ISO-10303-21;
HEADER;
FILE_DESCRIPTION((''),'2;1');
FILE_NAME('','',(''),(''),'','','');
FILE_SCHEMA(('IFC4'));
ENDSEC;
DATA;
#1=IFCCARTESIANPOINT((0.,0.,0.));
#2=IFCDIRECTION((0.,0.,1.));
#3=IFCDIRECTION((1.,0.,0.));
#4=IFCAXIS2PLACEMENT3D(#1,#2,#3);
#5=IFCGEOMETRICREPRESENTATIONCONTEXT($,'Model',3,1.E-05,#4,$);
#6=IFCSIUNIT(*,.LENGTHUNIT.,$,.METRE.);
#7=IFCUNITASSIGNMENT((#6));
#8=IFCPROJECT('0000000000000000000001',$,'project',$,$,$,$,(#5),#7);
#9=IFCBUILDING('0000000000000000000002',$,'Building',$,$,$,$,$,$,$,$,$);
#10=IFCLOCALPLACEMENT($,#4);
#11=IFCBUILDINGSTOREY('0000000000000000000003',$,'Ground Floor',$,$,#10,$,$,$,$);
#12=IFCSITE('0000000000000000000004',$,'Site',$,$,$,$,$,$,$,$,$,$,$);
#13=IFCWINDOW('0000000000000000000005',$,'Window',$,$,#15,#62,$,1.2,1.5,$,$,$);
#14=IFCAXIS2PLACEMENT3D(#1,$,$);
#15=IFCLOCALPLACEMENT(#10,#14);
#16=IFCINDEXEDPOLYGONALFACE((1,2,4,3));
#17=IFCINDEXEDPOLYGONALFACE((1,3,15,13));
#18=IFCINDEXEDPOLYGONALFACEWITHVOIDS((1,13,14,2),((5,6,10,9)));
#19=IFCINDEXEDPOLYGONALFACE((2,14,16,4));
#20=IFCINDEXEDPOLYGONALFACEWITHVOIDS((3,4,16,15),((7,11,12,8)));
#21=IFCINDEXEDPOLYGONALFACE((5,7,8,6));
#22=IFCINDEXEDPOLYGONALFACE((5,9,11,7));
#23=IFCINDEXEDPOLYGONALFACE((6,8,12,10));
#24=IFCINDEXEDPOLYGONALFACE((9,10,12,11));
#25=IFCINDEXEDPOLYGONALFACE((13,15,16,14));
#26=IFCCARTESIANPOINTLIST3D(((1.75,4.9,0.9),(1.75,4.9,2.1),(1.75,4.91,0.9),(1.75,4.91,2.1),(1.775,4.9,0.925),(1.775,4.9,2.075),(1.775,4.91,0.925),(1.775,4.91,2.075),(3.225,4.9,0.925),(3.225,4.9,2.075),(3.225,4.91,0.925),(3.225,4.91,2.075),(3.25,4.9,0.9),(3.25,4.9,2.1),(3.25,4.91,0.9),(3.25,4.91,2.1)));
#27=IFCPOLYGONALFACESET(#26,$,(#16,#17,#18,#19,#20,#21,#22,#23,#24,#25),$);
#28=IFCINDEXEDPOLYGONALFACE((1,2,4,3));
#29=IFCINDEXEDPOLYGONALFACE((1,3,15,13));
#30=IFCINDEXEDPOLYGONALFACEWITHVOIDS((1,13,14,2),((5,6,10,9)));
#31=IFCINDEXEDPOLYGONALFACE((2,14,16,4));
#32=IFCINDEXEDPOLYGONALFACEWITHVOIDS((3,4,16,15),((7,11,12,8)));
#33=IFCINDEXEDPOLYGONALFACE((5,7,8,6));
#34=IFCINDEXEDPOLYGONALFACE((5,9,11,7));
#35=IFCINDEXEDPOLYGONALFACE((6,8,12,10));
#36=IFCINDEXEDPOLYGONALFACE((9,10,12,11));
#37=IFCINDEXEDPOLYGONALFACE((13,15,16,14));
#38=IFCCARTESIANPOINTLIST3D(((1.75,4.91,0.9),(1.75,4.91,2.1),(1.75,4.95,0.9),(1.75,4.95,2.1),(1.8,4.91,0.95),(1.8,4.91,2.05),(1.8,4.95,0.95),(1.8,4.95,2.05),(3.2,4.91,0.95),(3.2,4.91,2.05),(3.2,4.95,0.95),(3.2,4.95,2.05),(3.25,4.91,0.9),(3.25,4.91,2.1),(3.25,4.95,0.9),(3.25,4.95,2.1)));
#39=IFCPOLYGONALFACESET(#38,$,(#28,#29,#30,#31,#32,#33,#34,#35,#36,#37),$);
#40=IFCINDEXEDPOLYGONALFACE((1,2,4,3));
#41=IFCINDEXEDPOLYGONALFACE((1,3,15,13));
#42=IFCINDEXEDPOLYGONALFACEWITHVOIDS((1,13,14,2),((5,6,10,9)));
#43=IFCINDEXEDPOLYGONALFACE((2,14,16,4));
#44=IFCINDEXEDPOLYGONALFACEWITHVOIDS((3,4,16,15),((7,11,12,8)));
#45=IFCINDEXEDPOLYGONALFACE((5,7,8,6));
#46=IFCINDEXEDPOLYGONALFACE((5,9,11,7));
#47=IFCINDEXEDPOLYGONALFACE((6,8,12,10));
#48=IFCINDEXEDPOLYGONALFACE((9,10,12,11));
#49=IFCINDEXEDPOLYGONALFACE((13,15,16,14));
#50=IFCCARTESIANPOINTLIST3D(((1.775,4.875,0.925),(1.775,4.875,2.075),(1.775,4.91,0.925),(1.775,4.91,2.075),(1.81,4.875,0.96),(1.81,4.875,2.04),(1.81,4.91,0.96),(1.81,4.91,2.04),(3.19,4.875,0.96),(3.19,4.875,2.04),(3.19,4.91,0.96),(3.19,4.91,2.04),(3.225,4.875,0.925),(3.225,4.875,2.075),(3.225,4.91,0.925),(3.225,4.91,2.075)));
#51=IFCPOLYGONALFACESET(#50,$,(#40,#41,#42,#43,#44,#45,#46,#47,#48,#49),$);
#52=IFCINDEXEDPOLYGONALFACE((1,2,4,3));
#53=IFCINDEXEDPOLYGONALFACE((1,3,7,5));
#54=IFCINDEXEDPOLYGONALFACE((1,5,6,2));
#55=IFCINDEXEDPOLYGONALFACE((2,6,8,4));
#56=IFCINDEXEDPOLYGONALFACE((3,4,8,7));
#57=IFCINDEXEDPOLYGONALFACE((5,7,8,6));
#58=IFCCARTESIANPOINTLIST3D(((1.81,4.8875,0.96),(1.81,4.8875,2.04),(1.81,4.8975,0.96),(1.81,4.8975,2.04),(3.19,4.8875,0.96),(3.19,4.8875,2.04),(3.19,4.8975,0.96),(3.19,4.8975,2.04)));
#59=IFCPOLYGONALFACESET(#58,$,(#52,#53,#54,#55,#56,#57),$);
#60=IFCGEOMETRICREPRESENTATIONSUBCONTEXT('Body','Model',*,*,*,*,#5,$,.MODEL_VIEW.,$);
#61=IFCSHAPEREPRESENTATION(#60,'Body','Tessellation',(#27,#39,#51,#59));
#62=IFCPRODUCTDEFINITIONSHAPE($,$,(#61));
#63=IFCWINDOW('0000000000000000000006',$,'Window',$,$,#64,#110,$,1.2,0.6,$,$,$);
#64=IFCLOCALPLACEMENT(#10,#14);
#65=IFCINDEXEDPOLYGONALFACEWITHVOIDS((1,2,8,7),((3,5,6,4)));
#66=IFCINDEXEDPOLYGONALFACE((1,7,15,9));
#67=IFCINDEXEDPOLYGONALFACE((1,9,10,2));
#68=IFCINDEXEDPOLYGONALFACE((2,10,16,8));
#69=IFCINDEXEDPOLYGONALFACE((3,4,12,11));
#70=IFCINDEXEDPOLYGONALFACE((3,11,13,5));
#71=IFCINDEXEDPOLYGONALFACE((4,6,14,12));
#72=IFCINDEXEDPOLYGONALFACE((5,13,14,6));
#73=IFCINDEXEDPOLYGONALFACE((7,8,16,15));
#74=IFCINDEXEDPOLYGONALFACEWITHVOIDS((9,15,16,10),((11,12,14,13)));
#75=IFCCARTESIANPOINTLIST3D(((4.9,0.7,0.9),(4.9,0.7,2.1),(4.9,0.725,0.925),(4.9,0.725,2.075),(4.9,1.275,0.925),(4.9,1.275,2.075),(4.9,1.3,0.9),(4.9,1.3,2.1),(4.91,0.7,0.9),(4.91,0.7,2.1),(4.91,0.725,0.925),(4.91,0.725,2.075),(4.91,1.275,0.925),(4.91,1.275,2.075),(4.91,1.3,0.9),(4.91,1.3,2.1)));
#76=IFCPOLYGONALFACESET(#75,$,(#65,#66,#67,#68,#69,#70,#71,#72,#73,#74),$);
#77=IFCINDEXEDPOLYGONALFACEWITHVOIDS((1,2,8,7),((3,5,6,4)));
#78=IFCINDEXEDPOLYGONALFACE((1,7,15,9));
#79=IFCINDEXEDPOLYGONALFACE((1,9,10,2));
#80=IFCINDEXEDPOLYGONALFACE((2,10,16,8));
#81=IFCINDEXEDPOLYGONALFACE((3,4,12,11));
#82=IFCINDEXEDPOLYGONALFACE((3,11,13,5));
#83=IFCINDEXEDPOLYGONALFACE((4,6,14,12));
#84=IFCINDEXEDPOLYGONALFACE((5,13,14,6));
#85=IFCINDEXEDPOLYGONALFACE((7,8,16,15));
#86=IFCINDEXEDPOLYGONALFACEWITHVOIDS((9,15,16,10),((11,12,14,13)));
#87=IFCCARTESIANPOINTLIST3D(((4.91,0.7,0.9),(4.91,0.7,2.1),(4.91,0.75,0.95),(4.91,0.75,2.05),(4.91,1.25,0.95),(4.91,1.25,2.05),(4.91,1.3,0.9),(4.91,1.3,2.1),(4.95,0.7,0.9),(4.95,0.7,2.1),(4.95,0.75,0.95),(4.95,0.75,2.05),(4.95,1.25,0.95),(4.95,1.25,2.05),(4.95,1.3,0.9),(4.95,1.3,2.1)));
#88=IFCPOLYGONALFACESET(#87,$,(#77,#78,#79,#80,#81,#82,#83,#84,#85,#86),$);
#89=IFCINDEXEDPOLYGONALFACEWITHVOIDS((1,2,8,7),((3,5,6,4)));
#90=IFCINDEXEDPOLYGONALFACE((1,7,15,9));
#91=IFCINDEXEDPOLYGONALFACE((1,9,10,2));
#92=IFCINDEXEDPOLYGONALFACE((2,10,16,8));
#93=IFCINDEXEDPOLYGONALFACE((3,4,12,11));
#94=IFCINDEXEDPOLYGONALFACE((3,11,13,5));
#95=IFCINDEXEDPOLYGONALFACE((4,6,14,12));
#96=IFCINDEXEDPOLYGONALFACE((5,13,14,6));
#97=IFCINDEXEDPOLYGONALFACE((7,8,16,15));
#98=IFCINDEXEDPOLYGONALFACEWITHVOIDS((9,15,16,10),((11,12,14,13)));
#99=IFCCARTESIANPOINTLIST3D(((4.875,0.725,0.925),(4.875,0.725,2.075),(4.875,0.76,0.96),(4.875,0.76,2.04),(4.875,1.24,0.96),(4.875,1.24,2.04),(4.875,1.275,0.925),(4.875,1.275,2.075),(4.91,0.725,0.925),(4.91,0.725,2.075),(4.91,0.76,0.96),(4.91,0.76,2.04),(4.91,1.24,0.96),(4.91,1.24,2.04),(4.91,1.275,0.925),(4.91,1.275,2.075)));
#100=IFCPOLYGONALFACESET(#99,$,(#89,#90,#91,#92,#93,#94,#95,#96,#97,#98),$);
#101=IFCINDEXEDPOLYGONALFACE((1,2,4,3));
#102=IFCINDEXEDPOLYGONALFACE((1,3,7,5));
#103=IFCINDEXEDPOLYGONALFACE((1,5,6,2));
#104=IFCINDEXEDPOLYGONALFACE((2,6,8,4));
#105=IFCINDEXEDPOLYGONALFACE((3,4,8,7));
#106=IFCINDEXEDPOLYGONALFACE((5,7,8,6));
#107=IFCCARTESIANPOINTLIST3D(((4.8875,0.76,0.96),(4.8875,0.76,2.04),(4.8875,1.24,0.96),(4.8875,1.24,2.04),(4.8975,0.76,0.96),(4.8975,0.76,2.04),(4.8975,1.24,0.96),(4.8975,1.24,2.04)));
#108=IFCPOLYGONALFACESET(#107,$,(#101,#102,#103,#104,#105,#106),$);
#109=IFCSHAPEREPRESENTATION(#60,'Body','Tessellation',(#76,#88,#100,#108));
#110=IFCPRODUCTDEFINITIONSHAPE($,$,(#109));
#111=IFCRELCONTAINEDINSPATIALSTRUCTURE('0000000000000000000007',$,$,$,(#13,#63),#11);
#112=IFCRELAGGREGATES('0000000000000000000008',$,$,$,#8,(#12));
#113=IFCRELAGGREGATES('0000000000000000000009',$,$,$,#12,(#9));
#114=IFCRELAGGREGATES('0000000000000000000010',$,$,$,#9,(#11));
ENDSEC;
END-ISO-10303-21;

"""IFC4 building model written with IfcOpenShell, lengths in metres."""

from ifc_helpers import new_model, si_unit, frame, origin_with_axes, place, context, subcontext, project, spatial, line, indexed_curve, outline, extrude, element, save


model = new_model("IFC4")

# Units and contexts
model_context = context("Model", 3, precision=1e-05, world=origin_with_axes())
body_context = subcontext(model_context, "Body", "Model", "MODEL_VIEW")
ifc_project = project(units=[si_unit("LENGTHUNIT", "METRE")], contexts=[model_context])

# Site, building, storey
site = spatial("IfcSite", under=ifc_project, Name="Site")
building = spatial("IfcBuilding", under=site, Name="Building")
storey_placement = place(None, origin_with_axes())
storey = spatial("IfcBuildingStorey", under=building, at=storey_placement, Name="Ground Floor")

# Windows
window_1_placement = place(storey_placement, frame((3.25, 5.0, 0.9), z_axis=(0.0, 0.0, 1.0), x_axis=(-1.0, 0.0, 0.0)))
element("IfcWindow", 1, at=window_1_placement, inside=storey, Name="Window", OverallHeight=1.2, OverallWidth=1.5, context=body_context, shape_type="SweptSolid", body=[
    extrude(outline(indexed_curve([(0.0, 0.0), (1.5, 0.0), (1.5, 1.2), (0.0, 1.2)], segments=[line(1, 2, 3, 4, 1)]), holes=[indexed_curve([(0.025, 0.025), (1.475, 0.025), (1.475, 1.175), (0.025, 1.175)], segments=[line(1, 2, 3, 4, 1)])]), frame((0.0, 0.09, 0.0), z_axis=(0.0, -1.0, 0.0), x_axis=(1.0, 0.0, 0.0)), (0.0, 0.0, -1.0), 0.01),
    extrude(outline(indexed_curve([(0.0, 0.0), (1.5, 0.0), (1.5, 1.2), (0.0, 1.2)], segments=[line(1, 2, 3, 4, 1)]), holes=[indexed_curve([(0.05, 0.05), (1.45, 0.05), (1.45, 1.15), (0.05, 1.15)], segments=[line(1, 2, 3, 4, 1)])]), frame((0.0, 0.05, 0.0), z_axis=(0.0, -1.0, 0.0), x_axis=(1.0, 0.0, 0.0)), (0.0, 0.0, -1.0), 0.04),
    extrude(outline(indexed_curve([(0.0, 0.0), (1.45, 0.0), (1.45, 1.15), (0.0, 1.15)], segments=[line(1, 2, 3, 4, 1)]), holes=[indexed_curve([(0.035, 0.035), (1.415, 0.035), (1.415, 1.115), (0.035, 1.115)], segments=[line(1, 2, 3, 4, 1)])]), frame((0.025, 0.09, 0.025), z_axis=(0.0, -1.0, 0.0), x_axis=(1.0, 0.0, 0.0)), (0.0, 0.0, -1.0), 0.035),
    extrude(outline(indexed_curve([(0.035, 0.035), (1.415, 0.035), (1.415, 1.115), (0.035, 1.115)], segments=[line(1, 2, 3, 4, 1)])), frame((0.025, 0.1025, 0.025), z_axis=(0.0, -1.0, 0.0), x_axis=(1.0, 0.0, 0.0)), (0.0, 0.0, -1.0), 0.01),
])
window_2_placement = place(storey_placement, frame((5.0, 0.7, 0.9), z_axis=(0.0, 0.0, 1.0), x_axis=(0.0, 1.0, 0.0)))
element("IfcWindow", 2, at=window_2_placement, inside=storey, Name="Window", OverallHeight=1.2, OverallWidth=0.6, context=body_context, shape_type="SweptSolid", body=[
    extrude(outline(indexed_curve([(0.0, 0.0), (0.6, 0.0), (0.6, 1.2), (0.0, 1.2)], segments=[line(1, 2, 3, 4, 1)]), holes=[indexed_curve([(0.025, 0.025), (0.575, 0.025), (0.575, 1.175), (0.025, 1.175)], segments=[line(1, 2, 3, 4, 1)])]), frame((0.0, 0.09, 0.0), z_axis=(0.0, -1.0, 0.0), x_axis=(1.0, 0.0, 0.0)), (0.0, 0.0, -1.0), 0.01),
    extrude(outline(indexed_curve([(0.0, 0.0), (0.6, 0.0), (0.6, 1.2), (0.0, 1.2)], segments=[line(1, 2, 3, 4, 1)]), holes=[indexed_curve([(0.05, 0.05), (0.55, 0.05), (0.55, 1.15), (0.05, 1.15)], segments=[line(1, 2, 3, 4, 1)])]), frame((0.0, 0.05, 0.0), z_axis=(0.0, -1.0, 0.0), x_axis=(1.0, 0.0, 0.0)), (0.0, 0.0, -1.0), 0.04),
    extrude(outline(indexed_curve([(0.0, 0.0), (0.55, 0.0), (0.55, 1.15), (0.0, 1.15)], segments=[line(1, 2, 3, 4, 1)]), holes=[indexed_curve([(0.035, 0.035), (0.515, 0.035), (0.515, 1.115), (0.035, 1.115)], segments=[line(1, 2, 3, 4, 1)])]), frame((0.025, 0.09, 0.025), z_axis=(0.0, -1.0, 0.0), x_axis=(1.0, 0.0, 0.0)), (0.0, 0.0, -1.0), 0.035),
    extrude(outline(indexed_curve([(0.035, 0.035), (0.515, 0.035), (0.515, 1.115), (0.035, 1.115)], segments=[line(1, 2, 3, 4, 1)])), frame((0.025, 0.1025, 0.025), z_axis=(0.0, -1.0, 0.0), x_axis=(1.0, 0.0, 0.0)), (0.0, 0.0, -1.0), 0.01),
])

save(model, "model.ifc")
